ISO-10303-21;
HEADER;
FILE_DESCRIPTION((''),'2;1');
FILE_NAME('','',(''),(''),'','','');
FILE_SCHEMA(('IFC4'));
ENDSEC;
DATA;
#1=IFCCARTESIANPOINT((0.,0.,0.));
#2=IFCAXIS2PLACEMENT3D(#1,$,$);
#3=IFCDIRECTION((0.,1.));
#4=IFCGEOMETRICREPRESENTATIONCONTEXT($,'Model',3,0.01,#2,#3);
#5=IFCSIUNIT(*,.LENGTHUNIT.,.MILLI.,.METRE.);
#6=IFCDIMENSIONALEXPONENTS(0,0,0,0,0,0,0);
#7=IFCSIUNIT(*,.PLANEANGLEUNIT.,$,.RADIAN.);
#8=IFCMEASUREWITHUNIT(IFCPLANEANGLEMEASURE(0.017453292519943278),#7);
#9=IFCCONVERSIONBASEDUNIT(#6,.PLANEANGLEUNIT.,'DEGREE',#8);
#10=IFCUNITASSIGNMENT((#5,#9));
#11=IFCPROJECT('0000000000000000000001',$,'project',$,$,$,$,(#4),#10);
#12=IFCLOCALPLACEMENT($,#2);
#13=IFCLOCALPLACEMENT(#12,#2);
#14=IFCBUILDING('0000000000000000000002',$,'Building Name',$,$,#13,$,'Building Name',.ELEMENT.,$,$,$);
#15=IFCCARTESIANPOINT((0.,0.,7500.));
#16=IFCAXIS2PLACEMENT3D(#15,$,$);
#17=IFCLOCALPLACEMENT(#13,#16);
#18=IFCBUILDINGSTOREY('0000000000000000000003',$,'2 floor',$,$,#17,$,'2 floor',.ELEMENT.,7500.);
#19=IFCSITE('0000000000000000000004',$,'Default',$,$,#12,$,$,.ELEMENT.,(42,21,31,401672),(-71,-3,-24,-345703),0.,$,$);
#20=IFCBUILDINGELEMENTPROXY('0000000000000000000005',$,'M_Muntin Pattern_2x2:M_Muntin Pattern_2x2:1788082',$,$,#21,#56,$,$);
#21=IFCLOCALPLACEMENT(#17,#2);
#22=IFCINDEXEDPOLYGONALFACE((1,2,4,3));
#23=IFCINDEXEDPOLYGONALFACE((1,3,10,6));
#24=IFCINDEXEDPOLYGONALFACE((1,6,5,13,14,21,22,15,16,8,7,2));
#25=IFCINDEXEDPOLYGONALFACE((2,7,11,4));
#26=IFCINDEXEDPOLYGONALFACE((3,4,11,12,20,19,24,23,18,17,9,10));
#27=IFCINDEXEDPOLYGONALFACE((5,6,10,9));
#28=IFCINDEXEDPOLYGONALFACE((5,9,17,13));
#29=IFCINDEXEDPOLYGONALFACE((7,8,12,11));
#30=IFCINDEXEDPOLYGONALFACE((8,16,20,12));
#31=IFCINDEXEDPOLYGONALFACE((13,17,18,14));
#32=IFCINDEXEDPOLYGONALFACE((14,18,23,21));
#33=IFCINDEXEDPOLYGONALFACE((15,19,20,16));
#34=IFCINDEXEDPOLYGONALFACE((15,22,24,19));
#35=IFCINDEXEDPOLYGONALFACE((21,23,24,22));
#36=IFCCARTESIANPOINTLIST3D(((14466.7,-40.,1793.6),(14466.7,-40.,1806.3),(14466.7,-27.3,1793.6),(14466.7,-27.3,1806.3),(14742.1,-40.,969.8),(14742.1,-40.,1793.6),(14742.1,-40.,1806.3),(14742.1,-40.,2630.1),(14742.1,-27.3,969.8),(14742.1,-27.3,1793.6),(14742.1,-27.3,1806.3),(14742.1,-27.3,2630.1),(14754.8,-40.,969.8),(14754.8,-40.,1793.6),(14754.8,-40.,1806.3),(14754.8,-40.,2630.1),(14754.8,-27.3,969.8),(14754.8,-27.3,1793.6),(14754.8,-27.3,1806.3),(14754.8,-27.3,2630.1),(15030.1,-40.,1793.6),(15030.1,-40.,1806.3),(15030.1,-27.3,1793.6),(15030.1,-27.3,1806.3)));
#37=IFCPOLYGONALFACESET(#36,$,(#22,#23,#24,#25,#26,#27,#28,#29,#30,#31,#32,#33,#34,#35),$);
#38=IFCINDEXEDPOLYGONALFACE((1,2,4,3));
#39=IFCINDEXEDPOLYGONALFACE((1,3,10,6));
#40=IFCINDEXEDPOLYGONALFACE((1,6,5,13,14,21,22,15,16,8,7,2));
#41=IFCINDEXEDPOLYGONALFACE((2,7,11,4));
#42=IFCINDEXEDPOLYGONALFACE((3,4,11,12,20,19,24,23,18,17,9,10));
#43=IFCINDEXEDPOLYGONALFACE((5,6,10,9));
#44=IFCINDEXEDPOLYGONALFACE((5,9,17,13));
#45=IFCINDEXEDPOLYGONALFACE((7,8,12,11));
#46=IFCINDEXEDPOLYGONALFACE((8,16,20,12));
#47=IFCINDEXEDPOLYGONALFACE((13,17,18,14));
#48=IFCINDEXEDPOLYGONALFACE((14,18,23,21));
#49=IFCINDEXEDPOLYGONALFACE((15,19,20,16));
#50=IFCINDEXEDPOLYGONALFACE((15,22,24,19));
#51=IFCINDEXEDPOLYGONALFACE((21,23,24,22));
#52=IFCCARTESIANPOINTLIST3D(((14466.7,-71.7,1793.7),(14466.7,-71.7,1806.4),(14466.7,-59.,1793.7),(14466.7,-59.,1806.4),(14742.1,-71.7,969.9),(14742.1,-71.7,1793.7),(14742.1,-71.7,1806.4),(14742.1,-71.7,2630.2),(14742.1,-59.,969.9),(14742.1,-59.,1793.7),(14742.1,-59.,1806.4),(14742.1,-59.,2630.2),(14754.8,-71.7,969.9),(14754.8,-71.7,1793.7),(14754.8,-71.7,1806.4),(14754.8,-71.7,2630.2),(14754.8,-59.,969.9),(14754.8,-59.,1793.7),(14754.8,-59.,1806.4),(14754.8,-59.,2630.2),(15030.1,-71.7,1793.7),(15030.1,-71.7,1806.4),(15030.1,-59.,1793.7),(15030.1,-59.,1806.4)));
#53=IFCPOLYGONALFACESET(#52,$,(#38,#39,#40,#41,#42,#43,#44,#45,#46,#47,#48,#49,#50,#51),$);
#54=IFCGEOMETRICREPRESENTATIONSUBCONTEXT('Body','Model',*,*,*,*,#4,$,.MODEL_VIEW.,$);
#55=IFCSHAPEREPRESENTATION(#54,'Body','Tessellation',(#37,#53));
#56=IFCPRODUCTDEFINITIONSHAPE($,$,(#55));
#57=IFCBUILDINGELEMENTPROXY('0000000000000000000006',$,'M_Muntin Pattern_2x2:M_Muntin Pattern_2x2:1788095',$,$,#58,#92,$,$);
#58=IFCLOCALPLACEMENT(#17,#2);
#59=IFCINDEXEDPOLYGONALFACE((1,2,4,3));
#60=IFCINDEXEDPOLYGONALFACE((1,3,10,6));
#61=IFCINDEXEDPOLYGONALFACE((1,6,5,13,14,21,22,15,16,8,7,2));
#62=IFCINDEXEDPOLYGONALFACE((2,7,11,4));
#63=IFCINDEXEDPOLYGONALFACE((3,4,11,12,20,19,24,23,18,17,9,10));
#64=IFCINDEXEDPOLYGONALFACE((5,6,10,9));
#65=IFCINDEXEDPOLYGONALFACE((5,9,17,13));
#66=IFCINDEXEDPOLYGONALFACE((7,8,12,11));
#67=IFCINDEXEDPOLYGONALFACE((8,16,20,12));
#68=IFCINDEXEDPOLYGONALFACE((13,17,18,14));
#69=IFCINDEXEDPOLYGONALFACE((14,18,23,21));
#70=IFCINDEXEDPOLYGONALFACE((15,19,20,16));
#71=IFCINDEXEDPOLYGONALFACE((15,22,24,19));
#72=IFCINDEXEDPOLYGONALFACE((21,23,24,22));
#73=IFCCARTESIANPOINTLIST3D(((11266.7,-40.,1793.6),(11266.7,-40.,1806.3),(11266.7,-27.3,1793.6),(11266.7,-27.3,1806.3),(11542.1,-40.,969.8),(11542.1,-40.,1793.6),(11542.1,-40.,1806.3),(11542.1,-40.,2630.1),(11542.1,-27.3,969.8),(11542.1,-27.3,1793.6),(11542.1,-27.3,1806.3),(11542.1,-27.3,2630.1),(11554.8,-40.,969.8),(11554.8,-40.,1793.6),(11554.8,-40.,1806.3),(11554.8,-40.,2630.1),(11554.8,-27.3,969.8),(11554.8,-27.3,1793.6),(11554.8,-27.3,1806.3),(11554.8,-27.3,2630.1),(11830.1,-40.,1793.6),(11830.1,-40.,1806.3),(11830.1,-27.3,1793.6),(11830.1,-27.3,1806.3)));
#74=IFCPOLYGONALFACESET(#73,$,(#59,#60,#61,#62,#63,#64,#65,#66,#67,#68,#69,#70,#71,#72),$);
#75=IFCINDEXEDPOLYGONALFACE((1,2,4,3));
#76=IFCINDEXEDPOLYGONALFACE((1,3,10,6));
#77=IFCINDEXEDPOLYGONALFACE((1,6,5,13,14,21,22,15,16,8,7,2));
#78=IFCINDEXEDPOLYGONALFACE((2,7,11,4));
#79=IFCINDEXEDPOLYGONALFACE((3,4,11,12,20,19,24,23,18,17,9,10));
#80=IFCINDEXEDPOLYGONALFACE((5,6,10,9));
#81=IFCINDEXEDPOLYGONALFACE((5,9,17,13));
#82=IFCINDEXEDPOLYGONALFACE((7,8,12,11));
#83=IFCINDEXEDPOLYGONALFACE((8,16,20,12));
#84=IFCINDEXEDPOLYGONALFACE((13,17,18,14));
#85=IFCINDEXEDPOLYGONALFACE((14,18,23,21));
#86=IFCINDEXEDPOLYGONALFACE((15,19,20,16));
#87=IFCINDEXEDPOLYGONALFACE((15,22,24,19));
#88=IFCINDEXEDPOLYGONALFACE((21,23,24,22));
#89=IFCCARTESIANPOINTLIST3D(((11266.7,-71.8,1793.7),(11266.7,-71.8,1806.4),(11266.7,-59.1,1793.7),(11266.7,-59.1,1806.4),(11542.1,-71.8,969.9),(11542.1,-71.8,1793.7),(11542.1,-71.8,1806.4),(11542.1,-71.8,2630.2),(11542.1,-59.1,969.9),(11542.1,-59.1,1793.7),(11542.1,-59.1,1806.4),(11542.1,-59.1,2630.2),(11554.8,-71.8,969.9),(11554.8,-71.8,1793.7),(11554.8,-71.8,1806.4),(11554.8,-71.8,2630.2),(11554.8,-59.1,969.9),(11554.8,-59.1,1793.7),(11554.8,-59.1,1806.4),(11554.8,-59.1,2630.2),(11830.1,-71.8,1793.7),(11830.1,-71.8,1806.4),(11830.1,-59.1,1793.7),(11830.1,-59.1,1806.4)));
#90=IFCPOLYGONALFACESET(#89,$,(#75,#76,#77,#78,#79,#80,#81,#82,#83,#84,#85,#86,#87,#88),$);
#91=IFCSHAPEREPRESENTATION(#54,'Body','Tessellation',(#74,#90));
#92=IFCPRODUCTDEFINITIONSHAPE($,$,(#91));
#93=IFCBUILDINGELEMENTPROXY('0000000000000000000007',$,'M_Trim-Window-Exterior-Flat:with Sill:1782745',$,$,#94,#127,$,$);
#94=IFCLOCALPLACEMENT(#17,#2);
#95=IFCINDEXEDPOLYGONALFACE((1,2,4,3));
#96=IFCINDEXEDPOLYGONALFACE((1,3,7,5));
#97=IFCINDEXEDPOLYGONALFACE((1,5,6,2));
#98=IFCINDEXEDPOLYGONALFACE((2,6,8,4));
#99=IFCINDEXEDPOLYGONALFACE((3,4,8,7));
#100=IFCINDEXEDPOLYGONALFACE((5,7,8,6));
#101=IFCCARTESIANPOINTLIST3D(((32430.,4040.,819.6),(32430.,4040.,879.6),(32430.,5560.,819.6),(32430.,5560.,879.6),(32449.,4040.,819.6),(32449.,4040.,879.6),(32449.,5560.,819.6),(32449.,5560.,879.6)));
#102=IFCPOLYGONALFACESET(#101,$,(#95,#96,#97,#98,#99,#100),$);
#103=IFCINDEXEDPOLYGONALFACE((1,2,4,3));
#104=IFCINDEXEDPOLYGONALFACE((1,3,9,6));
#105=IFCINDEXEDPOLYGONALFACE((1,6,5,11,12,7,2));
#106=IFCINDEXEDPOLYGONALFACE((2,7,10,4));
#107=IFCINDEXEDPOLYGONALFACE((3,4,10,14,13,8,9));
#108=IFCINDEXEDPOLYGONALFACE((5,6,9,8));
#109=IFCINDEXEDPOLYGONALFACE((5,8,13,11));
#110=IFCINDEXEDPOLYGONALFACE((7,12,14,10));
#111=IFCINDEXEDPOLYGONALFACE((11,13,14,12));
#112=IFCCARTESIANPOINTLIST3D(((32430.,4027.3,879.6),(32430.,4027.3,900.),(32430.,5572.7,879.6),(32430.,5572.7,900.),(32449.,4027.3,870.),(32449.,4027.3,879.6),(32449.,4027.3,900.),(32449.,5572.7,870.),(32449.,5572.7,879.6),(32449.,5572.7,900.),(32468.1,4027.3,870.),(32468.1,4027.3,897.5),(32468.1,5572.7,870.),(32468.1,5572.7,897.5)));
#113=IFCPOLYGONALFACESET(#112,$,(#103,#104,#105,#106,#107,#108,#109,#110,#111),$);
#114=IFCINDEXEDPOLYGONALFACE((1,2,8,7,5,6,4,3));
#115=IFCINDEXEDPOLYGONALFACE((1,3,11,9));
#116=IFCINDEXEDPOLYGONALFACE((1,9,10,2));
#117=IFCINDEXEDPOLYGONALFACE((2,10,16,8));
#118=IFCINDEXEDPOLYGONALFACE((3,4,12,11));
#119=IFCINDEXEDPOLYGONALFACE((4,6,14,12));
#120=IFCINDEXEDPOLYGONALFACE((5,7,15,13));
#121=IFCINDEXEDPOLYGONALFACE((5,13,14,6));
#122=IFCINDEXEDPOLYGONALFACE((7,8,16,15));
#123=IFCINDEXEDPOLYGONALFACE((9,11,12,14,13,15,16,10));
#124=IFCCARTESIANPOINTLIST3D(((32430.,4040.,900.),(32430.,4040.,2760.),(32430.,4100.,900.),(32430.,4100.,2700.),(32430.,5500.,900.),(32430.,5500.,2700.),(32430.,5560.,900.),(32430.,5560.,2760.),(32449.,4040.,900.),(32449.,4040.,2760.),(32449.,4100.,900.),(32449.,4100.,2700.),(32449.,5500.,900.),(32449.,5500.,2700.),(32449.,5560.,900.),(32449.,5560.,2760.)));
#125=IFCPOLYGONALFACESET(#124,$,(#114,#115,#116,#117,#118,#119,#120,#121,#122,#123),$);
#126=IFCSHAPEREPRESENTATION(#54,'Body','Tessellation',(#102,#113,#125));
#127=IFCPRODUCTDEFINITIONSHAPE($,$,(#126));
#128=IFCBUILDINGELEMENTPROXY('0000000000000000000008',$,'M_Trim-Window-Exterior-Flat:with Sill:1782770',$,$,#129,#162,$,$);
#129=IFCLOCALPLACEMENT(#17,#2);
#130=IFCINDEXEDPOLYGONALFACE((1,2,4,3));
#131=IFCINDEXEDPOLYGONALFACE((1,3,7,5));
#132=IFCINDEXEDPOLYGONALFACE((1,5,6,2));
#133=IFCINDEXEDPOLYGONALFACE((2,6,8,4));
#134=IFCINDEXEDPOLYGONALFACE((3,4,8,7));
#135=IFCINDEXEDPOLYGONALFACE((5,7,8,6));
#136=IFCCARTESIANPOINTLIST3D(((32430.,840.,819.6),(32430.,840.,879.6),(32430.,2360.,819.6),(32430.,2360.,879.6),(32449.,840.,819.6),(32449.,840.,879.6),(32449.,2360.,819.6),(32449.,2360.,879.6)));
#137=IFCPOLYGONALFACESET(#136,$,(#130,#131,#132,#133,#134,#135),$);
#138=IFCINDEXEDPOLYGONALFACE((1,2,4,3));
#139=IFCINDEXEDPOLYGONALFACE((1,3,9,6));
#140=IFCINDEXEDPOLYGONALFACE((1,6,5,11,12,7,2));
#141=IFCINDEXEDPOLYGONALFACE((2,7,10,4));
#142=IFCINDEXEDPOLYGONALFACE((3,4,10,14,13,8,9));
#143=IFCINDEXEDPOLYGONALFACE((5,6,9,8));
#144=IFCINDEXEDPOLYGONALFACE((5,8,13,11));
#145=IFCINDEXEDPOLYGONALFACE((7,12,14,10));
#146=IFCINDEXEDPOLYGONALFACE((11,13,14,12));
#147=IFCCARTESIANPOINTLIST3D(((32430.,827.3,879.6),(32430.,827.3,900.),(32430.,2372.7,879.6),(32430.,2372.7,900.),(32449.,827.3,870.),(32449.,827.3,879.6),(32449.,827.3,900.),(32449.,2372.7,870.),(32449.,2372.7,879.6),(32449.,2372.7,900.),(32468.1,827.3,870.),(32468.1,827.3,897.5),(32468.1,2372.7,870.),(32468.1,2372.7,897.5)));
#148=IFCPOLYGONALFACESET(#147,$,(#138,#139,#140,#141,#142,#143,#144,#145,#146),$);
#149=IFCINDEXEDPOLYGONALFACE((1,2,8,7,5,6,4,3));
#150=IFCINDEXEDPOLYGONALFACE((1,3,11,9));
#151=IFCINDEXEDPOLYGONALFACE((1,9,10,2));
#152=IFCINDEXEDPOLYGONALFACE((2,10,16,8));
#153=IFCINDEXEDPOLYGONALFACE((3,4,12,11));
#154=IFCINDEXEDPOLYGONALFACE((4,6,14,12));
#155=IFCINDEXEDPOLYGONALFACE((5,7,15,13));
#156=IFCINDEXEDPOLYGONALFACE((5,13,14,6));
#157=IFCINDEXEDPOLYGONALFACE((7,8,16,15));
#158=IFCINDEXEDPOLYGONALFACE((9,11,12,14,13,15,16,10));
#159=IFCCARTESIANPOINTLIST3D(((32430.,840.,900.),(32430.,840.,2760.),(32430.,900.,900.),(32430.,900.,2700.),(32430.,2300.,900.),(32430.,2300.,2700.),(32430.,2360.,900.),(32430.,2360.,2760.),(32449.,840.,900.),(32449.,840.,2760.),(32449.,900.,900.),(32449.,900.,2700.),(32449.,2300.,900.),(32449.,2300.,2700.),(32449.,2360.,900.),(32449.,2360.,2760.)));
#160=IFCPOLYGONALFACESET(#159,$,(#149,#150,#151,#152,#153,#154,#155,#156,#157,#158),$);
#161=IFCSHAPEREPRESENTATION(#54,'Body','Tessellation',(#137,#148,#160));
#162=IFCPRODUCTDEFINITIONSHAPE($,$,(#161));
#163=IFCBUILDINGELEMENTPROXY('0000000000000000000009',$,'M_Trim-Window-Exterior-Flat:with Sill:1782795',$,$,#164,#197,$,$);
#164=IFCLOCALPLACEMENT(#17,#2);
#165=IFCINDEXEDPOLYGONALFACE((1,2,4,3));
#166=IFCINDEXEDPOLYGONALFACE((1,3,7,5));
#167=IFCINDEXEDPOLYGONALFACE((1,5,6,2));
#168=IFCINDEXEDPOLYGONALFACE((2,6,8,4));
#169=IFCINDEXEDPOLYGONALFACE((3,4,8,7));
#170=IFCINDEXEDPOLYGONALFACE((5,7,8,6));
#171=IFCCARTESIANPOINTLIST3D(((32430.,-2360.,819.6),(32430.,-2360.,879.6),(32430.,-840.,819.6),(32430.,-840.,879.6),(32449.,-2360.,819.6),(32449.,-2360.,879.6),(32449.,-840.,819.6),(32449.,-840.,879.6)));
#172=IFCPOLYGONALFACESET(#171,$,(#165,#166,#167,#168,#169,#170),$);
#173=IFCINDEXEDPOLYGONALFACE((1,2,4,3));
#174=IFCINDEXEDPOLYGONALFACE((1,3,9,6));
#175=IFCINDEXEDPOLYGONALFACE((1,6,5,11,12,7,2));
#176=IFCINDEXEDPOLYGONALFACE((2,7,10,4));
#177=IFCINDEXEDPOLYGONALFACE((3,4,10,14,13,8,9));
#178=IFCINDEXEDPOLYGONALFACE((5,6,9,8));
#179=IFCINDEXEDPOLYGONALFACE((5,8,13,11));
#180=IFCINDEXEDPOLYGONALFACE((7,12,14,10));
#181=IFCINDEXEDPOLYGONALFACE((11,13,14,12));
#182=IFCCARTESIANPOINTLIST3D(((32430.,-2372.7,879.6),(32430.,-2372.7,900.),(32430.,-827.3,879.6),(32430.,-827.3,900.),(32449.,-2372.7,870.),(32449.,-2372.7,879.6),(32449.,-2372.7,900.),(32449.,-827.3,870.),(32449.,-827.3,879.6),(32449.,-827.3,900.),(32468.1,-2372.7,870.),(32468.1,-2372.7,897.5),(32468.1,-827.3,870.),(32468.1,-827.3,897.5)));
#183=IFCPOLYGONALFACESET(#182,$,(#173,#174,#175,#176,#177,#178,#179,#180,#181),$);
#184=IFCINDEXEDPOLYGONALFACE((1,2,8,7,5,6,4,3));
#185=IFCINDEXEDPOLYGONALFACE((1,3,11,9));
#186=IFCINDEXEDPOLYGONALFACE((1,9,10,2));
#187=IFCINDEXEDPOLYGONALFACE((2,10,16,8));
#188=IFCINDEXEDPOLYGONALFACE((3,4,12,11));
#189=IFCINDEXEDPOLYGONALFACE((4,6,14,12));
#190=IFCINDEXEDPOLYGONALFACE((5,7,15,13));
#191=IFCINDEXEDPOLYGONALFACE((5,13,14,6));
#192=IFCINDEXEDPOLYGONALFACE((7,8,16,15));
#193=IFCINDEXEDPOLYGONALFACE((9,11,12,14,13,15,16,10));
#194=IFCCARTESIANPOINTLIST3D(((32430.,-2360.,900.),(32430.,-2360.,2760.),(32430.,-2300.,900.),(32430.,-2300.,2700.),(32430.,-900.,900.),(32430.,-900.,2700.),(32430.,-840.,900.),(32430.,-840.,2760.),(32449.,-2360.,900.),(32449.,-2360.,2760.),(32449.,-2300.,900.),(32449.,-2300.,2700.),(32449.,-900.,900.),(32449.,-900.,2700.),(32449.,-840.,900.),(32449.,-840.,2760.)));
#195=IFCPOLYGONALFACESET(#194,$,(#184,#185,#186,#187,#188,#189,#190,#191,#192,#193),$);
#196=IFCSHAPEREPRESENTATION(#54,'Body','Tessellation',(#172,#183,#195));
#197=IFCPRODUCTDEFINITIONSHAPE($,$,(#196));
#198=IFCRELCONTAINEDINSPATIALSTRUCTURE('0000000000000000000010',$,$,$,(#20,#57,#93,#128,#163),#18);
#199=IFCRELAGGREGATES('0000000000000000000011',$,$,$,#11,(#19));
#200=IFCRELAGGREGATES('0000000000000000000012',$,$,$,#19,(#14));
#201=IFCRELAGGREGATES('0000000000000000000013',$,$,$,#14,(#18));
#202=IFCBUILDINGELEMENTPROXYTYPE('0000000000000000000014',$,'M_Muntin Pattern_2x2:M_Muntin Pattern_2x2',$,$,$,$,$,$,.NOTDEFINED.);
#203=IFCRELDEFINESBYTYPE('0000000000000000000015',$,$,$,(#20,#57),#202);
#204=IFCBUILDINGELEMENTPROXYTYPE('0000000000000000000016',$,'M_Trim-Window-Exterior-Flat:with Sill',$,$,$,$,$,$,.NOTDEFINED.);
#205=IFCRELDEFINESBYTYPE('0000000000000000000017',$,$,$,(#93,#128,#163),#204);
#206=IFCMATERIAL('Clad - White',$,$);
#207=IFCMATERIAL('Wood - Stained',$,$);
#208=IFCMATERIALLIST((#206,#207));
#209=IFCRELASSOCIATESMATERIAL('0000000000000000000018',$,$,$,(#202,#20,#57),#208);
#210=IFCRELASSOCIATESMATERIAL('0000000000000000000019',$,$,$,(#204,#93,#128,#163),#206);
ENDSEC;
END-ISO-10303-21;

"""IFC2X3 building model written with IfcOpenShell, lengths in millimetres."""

from ifc_helpers import new_model, entity, si_unit, converted_unit, direction, frame, frame_2d, origin, place, context, subcontext, project, spatial, polyline, rectangle, outline, extrude, source, transform, mapped, material, material_list, type_object, type_shapes, element, save


model = new_model("IFC2X3")

# Units and contexts
model_context = context("Model", 3, precision=0.01, world=origin(), true_north=direction((0.0, 1.0)))
body_context = subcontext(model_context, "Body", "Model", "MODEL_VIEW")
ifc_project = project(units=[si_unit("LENGTHUNIT", "METRE", prefix="MILLI"), converted_unit("PLANEANGLEUNIT", "DEGREE", entity("IfcPlaneAngleMeasure", 0.017453292519943278), si_unit("PLANEANGLEUNIT", "RADIAN"), dimensions=[0, 0, 0, 0, 0, 0, 0])], contexts=[model_context])

# Site, building, storey
site_placement = place(None, origin())
site = spatial("IfcSite", under=ifc_project, at=site_placement, Name="Default", CompositionType="ELEMENT", RefLatitude=(42, 21, 31, 401672), RefLongitude=(-71, -3, -24, -345703), RefElevation=0.0)
building_placement = place(site_placement, origin())
building = spatial("IfcBuilding", under=site, at=building_placement, Name="Building Name", LongName="Building Name", CompositionType="ELEMENT")
storey_placement = place(building_placement, frame((0.0, 0.0, 7500.0)))
storey = spatial("IfcBuildingStorey", under=building, at=storey_placement, Name="2 floor", LongName="2 floor", CompositionType="ELEMENT", Elevation=7500.0)

# Building element proxies
ifc_material_1 = material(Name="Clad - White")
ifc_material_2 = material(Name="Wood - Stained")
ifc_material_list = material_list([ifc_material_1, ifc_material_2])
building_element_proxy_type_1 = type_object("IfcBuildingElementProxyType", Name="M_Muntin Pattern_2x2:M_Muntin Pattern_2x2", PredefinedType="NOTDEFINED", material=ifc_material_list)
shared_shape_1 = source(origin(), body_context, "Body", "SweptSolid", [
    extrude(outline(polyline([(6.4, -6.4), (830.1, -6.4), (830.1, 6.3), (6.4, 6.3), (6.4, 281.7), (-6.3, 281.7), (-6.3, 6.3), (-830.2, 6.3), (-830.2, -6.4), (-6.3, -6.4), (-6.3, -281.7), (6.4, -281.7), (6.4, -6.4)])), frame((0.0, -22.2, 830.1), z_axis=(0.0, 1.0, 0.0), x_axis=(0.0, 0.0, 1.0)), (0.0, 0.0, 1.0), 12.7),
    extrude(outline(polyline([(6.4, -6.4), (830.2, -6.4), (830.2, 6.3), (6.4, 6.3), (6.4, 281.7), (-6.3, 281.7), (-6.3, 6.3), (-830.2, 6.3), (-830.2, -6.4), (-6.3, -6.4), (-6.3, -281.7), (6.4, -281.7), (6.4, -6.4)])), frame((0.0, 9.5, 830.2), z_axis=(0.0, 1.0, 0.0), x_axis=(0.0, 0.0, 1.0)), (0.0, 0.0, 1.0), 12.7),
])
type_shapes(building_element_proxy_type_1, [shared_shape_1])
for number, where, z_axis, x_axis, name in (
    (1, (14748.4, -49.5, 969.9), (0.0, 0.0, 1.0), (-1.0, 0.0, 0.0), "M_Muntin Pattern_2x2:M_Muntin Pattern_2x2:1788082"),
    (2, (11548.4, -49.5, 969.9), (0.0, 0.0, 1.0), (-1.0, 0.0, 0.0), "M_Muntin Pattern_2x2:M_Muntin Pattern_2x2:1788095"),
):
    element("IfcBuildingElementProxy", number, at=place(storey_placement, frame(where, z_axis=z_axis, x_axis=x_axis)), inside=storey, type_object=building_element_proxy_type_1, material=ifc_material_list, Name=name, context=body_context, shape_type="MappedRepresentation", body=[
        mapped(shared_shape_1, transform((0.0, 0.0, 0.0), scale=1.0)),
    ])
building_element_proxy_type_2 = type_object("IfcBuildingElementProxyType", Name="M_Trim-Window-Exterior-Flat:with Sill", PredefinedType="NOTDEFINED", material=ifc_material_1)
shared_shape_2 = source(origin(), body_context, "Body", "SweptSolid", [
    extrude(rectangle(XDim=1520.0, YDim=60.0, at=frame_2d((0.0, 0.0), x_axis=(1.0, 0.0))), frame((0.0, -1850.4, 0.0), z_axis=(0.0, 0.0, 1.0), x_axis=(-1.0, 0.0, 0.0)), (0.0, 0.0, 1.0), 19.0),
    extrude(outline(polyline([(-19.0, -15.2), (0.0, -15.2), (0.0, -5.7), (19.0, -5.7), (19.0, 14.8), (0.0, 14.8), (-19.0, 12.3), (-19.0, -15.2)])), frame((-772.7, -1814.8, 19.0), z_axis=(1.0, 0.0, 0.0), x_axis=(0.0, 0.0, -1.0)), (0.0, 0.0, 1.0), 1545.4),
    extrude(outline(polyline([(-945.0, -760.0), (915.0, -760.0), (915.0, -700.0), (-885.0, -700.0), (-885.0, 700.0), (915.0, 700.0), (915.0, 760.0), (-945.0, 760.0), (-945.0, -760.0)])), frame((0.0, -885.0, 0.0), z_axis=(0.0, 0.0, 1.0), x_axis=(0.0, -1.0, 0.0)), (0.0, 0.0, 1.0), 19.0),
])
type_shapes(building_element_proxy_type_2, [shared_shape_2])
for number, where, z_axis, x_axis, name in (
    (3, (32430.0, 4800.0, 2700.0), (1.0, 0.0, 0.0), (0.0, 1.0, 0.0), "M_Trim-Window-Exterior-Flat:with Sill:1782745"),
    (4, (32430.0, 1600.0, 2700.0), (1.0, 0.0, 0.0), (0.0, 1.0, 0.0), "M_Trim-Window-Exterior-Flat:with Sill:1782770"),
    (5, (32430.0, -1600.0, 2700.0), (1.0, 0.0, 0.0), (0.0, 1.0, 0.0), "M_Trim-Window-Exterior-Flat:with Sill:1782795"),
):
    element("IfcBuildingElementProxy", number, at=place(storey_placement, frame(where, z_axis=z_axis, x_axis=x_axis)), inside=storey, type_object=building_element_proxy_type_2, material=ifc_material_1, Name=name, context=body_context, shape_type="MappedRepresentation", body=[
        mapped(shared_shape_2, transform((0.0, 0.0, 0.0), scale=1.0)),
    ])

save(model, "model.ifc")
